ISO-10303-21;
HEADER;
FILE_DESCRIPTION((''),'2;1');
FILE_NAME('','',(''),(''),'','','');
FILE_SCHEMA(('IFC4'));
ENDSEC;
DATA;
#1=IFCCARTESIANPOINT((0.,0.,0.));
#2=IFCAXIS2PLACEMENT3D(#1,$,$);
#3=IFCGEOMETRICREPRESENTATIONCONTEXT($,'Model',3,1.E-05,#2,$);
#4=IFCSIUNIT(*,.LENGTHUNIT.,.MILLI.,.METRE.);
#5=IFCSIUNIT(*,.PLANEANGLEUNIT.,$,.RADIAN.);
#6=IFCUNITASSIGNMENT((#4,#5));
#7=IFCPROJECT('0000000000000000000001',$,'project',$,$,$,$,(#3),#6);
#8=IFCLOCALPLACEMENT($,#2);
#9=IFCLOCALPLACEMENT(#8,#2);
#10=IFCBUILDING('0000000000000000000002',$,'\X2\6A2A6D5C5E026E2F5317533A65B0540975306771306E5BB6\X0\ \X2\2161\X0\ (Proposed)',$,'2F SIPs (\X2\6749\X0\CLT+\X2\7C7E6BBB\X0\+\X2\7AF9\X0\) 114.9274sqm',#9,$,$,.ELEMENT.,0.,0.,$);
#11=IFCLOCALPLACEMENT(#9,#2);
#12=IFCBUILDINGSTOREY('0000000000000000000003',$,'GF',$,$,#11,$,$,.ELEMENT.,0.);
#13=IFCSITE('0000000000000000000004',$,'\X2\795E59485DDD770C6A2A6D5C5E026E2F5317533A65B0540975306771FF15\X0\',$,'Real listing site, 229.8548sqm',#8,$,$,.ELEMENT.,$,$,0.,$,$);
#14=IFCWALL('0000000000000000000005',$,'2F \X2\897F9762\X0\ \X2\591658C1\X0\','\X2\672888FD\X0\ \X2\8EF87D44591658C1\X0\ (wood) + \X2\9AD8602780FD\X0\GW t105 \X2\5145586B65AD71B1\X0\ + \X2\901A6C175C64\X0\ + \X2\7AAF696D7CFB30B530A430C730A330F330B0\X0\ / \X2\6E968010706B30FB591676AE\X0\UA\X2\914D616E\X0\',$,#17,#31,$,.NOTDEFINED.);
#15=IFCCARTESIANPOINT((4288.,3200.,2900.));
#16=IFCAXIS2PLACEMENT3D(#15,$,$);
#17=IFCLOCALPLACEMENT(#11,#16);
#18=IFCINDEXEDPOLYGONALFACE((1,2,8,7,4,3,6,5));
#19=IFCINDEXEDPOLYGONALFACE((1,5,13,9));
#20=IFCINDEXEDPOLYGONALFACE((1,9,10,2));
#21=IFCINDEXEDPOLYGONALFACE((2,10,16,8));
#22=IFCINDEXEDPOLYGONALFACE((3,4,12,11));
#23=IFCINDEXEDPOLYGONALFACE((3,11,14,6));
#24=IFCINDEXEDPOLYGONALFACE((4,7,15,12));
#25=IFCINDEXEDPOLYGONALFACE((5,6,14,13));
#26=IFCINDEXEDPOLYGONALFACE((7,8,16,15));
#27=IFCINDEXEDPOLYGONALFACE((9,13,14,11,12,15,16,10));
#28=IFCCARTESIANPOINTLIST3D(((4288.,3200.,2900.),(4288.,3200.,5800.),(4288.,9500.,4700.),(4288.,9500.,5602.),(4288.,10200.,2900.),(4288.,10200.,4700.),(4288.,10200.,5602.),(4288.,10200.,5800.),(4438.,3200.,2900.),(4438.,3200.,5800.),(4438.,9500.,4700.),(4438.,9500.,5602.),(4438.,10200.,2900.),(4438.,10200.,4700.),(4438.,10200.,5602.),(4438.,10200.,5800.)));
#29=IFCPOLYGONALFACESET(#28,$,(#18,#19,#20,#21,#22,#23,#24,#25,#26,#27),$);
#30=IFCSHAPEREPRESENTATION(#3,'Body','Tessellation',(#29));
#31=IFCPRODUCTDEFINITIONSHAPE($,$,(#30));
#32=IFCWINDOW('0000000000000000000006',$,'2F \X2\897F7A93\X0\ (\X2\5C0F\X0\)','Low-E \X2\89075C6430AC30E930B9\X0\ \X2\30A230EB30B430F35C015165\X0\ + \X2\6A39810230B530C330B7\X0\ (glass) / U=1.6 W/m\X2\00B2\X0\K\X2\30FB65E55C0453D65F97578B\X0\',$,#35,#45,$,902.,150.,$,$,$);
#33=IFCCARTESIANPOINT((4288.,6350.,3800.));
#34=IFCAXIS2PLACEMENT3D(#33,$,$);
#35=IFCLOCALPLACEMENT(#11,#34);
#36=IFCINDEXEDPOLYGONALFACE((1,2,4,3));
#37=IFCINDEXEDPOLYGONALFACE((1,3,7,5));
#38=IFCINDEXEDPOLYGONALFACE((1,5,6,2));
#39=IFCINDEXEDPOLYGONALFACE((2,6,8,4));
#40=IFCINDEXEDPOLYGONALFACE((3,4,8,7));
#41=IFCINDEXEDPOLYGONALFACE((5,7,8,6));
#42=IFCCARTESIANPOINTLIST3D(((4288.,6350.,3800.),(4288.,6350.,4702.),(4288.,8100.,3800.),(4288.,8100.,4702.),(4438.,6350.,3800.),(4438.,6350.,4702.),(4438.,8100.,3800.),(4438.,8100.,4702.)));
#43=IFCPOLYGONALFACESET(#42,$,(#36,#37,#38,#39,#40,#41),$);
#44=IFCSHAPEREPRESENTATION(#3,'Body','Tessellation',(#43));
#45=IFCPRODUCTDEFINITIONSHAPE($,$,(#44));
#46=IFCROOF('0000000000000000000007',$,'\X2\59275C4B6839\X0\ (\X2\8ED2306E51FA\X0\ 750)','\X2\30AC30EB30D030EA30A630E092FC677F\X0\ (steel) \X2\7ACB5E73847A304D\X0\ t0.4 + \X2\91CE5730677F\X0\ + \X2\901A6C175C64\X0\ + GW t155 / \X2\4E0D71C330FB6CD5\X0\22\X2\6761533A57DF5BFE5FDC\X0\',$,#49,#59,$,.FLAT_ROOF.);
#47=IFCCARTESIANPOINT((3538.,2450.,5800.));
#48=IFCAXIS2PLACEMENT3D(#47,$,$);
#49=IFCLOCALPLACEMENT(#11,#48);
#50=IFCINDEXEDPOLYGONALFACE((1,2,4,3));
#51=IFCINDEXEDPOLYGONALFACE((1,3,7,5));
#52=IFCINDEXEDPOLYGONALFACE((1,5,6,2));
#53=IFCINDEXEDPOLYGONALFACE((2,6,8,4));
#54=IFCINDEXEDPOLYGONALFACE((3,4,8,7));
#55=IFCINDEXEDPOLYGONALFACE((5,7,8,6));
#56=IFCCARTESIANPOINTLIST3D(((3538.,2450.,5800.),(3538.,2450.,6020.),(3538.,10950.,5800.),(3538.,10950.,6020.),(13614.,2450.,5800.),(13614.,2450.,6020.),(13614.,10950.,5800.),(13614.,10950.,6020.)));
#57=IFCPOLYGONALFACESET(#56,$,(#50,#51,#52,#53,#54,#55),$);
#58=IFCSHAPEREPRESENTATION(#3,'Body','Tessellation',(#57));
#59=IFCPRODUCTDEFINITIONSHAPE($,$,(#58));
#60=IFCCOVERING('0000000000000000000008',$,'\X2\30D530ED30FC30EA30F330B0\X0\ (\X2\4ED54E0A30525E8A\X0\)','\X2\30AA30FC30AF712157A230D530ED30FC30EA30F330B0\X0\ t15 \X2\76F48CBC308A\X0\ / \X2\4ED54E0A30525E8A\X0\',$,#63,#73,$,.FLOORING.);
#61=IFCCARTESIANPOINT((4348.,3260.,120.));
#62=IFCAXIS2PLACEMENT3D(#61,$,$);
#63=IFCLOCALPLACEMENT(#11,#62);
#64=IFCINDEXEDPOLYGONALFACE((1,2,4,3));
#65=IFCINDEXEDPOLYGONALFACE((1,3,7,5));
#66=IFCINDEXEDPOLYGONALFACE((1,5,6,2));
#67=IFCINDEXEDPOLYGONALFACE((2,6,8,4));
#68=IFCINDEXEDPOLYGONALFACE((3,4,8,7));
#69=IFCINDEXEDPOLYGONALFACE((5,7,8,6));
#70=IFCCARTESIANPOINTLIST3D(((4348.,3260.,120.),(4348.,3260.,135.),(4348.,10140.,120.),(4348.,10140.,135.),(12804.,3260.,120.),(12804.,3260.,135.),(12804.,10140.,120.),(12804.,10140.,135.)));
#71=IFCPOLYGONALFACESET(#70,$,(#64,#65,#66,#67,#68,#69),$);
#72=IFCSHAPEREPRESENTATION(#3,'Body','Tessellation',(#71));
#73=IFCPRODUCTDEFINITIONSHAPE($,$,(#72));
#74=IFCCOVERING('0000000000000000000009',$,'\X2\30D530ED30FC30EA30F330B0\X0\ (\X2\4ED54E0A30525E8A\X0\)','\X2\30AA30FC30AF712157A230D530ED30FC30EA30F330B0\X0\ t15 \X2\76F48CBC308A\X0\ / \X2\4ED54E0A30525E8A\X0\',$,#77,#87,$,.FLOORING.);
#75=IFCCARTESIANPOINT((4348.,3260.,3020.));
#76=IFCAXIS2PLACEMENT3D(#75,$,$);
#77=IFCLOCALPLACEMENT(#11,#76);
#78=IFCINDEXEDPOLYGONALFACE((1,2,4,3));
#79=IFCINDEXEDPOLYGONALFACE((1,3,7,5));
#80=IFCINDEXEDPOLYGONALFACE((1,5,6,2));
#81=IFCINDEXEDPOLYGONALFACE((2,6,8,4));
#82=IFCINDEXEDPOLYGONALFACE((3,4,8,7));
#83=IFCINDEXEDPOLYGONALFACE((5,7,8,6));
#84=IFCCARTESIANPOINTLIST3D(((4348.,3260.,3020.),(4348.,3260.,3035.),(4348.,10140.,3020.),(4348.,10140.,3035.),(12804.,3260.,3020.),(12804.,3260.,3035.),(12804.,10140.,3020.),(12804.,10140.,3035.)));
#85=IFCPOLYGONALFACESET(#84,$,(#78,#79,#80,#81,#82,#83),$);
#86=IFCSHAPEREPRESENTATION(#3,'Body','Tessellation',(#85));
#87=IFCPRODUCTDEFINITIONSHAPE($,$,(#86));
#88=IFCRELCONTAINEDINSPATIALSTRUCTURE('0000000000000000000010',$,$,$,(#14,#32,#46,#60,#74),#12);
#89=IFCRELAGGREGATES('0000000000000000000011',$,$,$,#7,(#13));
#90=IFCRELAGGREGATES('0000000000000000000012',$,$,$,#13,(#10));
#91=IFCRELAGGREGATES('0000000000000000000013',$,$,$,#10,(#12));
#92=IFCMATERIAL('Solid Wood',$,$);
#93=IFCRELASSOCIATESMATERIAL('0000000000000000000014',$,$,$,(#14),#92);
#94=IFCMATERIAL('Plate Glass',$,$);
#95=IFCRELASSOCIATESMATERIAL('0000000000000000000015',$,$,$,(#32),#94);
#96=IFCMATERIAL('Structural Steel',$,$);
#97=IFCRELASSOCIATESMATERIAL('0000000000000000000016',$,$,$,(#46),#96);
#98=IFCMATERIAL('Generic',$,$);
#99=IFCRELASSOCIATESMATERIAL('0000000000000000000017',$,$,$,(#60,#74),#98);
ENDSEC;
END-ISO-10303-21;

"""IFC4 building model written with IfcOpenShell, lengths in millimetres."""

from ifc_helpers import new_model, si_unit, frame, frame_2d, origin, place, context, project, spatial, rectangle, extrude, material, element, fill, save


model = new_model("IFC4")

# Units and contexts
model_context = context("Model", 3, precision=1e-05, world=origin())
ifc_project = project(units=[si_unit("LENGTHUNIT", "METRE", prefix="MILLI"), si_unit("PLANEANGLEUNIT", "RADIAN")], contexts=[model_context])

# Site, building, storey
site_placement = place(None, origin())
site = spatial("IfcSite", under=ifc_project, at=site_placement, Name="神奈川県横浜市港北区新吉田東５", ObjectType="Real listing site, 229.8548sqm", CompositionType="ELEMENT", RefElevation=0.0)
building_placement = place(site_placement, origin())
building = spatial("IfcBuilding", under=site, at=building_placement, Name="横浜市港北区新吉田東の家 Ⅱ (Proposed)", ObjectType="2F SIPs (杉CLT+籾殻+竹) 114.9274sqm", CompositionType="ELEMENT", ElevationOfRefHeight=0.0, ElevationOfTerrain=0.0)
storey_placement = place(building_placement, origin())
storey = spatial("IfcBuildingStorey", under=building, at=storey_placement, Name="GF", CompositionType="ELEMENT", Elevation=0.0)

# Shared definitions
ifc_material_1 = material(Name="Solid Wood")

# Shared definitions
ifc_material_2 = material(Name="Plate Glass")

# Wall, opening, window
wall_1_placement = place(storey_placement, frame((4288.0, 3200.0, 2900.0)))
wall_1 = element("IfcWall", 1, at=wall_1_placement, inside=storey, material=ifc_material_1, Name="2F 西面 外壁", Description="木製 軸組外壁 (wood) + 高性能GW t105 充填断熱 + 通気層 + 窯業系サイディング / 準耐火・外皮UA配慮", PredefinedType="NOTDEFINED", context=model_context, shape_type="SweptSolid", body=[
    extrude(rectangle(XDim=150.0, YDim=7000.0, at=frame_2d((75.0, 3500.0))), frame((4288.0, 3200.0, 2900.0)), (0.0, 0.0, 1.0), 2900.0),
])
opening_1_placement = place(storey_placement, frame((4288.0, 6350.0, 3800.0)))
opening_1 = element("IfcOpeningElement", 2, at=opening_1_placement, cuts=wall_1, PredefinedType="NOTDEFINED", context=model_context, shape_type="SweptSolid", body=[
    extrude(rectangle(XDim=150.0, YDim=1750.0, at=frame_2d((75.0, 875.0))), frame((4288.0, 6350.0, 3800.0)), (0.0, 0.0, 1.0), 902.0),
])
window_1_placement = place(storey_placement, frame((4288.0, 6350.0, 3800.0)))
window_1 = element("IfcWindow", 3, at=window_1_placement, inside=storey, material=ifc_material_2, Name="2F 西窓 (小)", Description="Low-E 複層ガラス アルゴン封入 + 樹脂サッシ (glass) / U=1.6 W/m²K・日射取得型", OverallHeight=902.0, OverallWidth=150.0, context=model_context, shape_type="SweptSolid", body=[
    extrude(rectangle(XDim=150.0, YDim=1750.0, at=frame_2d((75.0, 875.0))), frame((4288.0, 6350.0, 3800.0)), (0.0, 0.0, 1.0), 902.0),
])
fill(opening_1, window_1)

# Roof
ifc_material_3 = material(Name="Structural Steel")
roof_placement = place(storey_placement, frame((3538.0, 2450.0, 5800.0)))
element("IfcRoof", 4, at=roof_placement, inside=storey, material=ifc_material_3, Name="大屋根 (軒の出 750)", Description="ガルバリウム鋼板 (steel) 立平葺き t0.4 + 野地板 + 通気層 + GW t155 / 不燃・法22条区域対応", PredefinedType="FLAT_ROOF", context=model_context, shape_type="SweptSolid", body=[
    extrude(rectangle(XDim=10076.0, YDim=8500.0, at=frame_2d((5038.0, 4250.0))), frame((3538.0, 2450.0, 5800.0)), (0.0, 0.0, 1.0), 220.0),
])

# Coverings
ifc_material_4 = material(Name="Generic")
covering_1_placement = place(storey_placement, frame((4348.0, 3260.0, 120.0)))
element("IfcCovering", 5, at=covering_1_placement, inside=storey, material=ifc_material_4, Name="フローリング (仕上げ床)", Description="オーク無垢フローリング t15 直貼り / 仕上げ床", PredefinedType="FLOORING", context=model_context, shape_type="SweptSolid", body=[
    extrude(rectangle(XDim=8456.0, YDim=6880.0, at=frame_2d((4228.0, 3440.0))), frame((4348.0, 3260.0, 120.0)), (0.0, 0.0, 1.0), 15.0),
])
covering_2_placement = place(storey_placement, frame((4348.0, 3260.0, 3020.0)))
element("IfcCovering", 6, at=covering_2_placement, inside=storey, material=ifc_material_4, Name="フローリング (仕上げ床)", Description="オーク無垢フローリング t15 直貼り / 仕上げ床", PredefinedType="FLOORING", context=model_context, shape_type="SweptSolid", body=[
    extrude(rectangle(XDim=8456.0, YDim=6880.0, at=frame_2d((4228.0, 3440.0))), frame((4348.0, 3260.0, 3020.0)), (0.0, 0.0, 1.0), 15.0),
])

save(model, "model.ifc")
